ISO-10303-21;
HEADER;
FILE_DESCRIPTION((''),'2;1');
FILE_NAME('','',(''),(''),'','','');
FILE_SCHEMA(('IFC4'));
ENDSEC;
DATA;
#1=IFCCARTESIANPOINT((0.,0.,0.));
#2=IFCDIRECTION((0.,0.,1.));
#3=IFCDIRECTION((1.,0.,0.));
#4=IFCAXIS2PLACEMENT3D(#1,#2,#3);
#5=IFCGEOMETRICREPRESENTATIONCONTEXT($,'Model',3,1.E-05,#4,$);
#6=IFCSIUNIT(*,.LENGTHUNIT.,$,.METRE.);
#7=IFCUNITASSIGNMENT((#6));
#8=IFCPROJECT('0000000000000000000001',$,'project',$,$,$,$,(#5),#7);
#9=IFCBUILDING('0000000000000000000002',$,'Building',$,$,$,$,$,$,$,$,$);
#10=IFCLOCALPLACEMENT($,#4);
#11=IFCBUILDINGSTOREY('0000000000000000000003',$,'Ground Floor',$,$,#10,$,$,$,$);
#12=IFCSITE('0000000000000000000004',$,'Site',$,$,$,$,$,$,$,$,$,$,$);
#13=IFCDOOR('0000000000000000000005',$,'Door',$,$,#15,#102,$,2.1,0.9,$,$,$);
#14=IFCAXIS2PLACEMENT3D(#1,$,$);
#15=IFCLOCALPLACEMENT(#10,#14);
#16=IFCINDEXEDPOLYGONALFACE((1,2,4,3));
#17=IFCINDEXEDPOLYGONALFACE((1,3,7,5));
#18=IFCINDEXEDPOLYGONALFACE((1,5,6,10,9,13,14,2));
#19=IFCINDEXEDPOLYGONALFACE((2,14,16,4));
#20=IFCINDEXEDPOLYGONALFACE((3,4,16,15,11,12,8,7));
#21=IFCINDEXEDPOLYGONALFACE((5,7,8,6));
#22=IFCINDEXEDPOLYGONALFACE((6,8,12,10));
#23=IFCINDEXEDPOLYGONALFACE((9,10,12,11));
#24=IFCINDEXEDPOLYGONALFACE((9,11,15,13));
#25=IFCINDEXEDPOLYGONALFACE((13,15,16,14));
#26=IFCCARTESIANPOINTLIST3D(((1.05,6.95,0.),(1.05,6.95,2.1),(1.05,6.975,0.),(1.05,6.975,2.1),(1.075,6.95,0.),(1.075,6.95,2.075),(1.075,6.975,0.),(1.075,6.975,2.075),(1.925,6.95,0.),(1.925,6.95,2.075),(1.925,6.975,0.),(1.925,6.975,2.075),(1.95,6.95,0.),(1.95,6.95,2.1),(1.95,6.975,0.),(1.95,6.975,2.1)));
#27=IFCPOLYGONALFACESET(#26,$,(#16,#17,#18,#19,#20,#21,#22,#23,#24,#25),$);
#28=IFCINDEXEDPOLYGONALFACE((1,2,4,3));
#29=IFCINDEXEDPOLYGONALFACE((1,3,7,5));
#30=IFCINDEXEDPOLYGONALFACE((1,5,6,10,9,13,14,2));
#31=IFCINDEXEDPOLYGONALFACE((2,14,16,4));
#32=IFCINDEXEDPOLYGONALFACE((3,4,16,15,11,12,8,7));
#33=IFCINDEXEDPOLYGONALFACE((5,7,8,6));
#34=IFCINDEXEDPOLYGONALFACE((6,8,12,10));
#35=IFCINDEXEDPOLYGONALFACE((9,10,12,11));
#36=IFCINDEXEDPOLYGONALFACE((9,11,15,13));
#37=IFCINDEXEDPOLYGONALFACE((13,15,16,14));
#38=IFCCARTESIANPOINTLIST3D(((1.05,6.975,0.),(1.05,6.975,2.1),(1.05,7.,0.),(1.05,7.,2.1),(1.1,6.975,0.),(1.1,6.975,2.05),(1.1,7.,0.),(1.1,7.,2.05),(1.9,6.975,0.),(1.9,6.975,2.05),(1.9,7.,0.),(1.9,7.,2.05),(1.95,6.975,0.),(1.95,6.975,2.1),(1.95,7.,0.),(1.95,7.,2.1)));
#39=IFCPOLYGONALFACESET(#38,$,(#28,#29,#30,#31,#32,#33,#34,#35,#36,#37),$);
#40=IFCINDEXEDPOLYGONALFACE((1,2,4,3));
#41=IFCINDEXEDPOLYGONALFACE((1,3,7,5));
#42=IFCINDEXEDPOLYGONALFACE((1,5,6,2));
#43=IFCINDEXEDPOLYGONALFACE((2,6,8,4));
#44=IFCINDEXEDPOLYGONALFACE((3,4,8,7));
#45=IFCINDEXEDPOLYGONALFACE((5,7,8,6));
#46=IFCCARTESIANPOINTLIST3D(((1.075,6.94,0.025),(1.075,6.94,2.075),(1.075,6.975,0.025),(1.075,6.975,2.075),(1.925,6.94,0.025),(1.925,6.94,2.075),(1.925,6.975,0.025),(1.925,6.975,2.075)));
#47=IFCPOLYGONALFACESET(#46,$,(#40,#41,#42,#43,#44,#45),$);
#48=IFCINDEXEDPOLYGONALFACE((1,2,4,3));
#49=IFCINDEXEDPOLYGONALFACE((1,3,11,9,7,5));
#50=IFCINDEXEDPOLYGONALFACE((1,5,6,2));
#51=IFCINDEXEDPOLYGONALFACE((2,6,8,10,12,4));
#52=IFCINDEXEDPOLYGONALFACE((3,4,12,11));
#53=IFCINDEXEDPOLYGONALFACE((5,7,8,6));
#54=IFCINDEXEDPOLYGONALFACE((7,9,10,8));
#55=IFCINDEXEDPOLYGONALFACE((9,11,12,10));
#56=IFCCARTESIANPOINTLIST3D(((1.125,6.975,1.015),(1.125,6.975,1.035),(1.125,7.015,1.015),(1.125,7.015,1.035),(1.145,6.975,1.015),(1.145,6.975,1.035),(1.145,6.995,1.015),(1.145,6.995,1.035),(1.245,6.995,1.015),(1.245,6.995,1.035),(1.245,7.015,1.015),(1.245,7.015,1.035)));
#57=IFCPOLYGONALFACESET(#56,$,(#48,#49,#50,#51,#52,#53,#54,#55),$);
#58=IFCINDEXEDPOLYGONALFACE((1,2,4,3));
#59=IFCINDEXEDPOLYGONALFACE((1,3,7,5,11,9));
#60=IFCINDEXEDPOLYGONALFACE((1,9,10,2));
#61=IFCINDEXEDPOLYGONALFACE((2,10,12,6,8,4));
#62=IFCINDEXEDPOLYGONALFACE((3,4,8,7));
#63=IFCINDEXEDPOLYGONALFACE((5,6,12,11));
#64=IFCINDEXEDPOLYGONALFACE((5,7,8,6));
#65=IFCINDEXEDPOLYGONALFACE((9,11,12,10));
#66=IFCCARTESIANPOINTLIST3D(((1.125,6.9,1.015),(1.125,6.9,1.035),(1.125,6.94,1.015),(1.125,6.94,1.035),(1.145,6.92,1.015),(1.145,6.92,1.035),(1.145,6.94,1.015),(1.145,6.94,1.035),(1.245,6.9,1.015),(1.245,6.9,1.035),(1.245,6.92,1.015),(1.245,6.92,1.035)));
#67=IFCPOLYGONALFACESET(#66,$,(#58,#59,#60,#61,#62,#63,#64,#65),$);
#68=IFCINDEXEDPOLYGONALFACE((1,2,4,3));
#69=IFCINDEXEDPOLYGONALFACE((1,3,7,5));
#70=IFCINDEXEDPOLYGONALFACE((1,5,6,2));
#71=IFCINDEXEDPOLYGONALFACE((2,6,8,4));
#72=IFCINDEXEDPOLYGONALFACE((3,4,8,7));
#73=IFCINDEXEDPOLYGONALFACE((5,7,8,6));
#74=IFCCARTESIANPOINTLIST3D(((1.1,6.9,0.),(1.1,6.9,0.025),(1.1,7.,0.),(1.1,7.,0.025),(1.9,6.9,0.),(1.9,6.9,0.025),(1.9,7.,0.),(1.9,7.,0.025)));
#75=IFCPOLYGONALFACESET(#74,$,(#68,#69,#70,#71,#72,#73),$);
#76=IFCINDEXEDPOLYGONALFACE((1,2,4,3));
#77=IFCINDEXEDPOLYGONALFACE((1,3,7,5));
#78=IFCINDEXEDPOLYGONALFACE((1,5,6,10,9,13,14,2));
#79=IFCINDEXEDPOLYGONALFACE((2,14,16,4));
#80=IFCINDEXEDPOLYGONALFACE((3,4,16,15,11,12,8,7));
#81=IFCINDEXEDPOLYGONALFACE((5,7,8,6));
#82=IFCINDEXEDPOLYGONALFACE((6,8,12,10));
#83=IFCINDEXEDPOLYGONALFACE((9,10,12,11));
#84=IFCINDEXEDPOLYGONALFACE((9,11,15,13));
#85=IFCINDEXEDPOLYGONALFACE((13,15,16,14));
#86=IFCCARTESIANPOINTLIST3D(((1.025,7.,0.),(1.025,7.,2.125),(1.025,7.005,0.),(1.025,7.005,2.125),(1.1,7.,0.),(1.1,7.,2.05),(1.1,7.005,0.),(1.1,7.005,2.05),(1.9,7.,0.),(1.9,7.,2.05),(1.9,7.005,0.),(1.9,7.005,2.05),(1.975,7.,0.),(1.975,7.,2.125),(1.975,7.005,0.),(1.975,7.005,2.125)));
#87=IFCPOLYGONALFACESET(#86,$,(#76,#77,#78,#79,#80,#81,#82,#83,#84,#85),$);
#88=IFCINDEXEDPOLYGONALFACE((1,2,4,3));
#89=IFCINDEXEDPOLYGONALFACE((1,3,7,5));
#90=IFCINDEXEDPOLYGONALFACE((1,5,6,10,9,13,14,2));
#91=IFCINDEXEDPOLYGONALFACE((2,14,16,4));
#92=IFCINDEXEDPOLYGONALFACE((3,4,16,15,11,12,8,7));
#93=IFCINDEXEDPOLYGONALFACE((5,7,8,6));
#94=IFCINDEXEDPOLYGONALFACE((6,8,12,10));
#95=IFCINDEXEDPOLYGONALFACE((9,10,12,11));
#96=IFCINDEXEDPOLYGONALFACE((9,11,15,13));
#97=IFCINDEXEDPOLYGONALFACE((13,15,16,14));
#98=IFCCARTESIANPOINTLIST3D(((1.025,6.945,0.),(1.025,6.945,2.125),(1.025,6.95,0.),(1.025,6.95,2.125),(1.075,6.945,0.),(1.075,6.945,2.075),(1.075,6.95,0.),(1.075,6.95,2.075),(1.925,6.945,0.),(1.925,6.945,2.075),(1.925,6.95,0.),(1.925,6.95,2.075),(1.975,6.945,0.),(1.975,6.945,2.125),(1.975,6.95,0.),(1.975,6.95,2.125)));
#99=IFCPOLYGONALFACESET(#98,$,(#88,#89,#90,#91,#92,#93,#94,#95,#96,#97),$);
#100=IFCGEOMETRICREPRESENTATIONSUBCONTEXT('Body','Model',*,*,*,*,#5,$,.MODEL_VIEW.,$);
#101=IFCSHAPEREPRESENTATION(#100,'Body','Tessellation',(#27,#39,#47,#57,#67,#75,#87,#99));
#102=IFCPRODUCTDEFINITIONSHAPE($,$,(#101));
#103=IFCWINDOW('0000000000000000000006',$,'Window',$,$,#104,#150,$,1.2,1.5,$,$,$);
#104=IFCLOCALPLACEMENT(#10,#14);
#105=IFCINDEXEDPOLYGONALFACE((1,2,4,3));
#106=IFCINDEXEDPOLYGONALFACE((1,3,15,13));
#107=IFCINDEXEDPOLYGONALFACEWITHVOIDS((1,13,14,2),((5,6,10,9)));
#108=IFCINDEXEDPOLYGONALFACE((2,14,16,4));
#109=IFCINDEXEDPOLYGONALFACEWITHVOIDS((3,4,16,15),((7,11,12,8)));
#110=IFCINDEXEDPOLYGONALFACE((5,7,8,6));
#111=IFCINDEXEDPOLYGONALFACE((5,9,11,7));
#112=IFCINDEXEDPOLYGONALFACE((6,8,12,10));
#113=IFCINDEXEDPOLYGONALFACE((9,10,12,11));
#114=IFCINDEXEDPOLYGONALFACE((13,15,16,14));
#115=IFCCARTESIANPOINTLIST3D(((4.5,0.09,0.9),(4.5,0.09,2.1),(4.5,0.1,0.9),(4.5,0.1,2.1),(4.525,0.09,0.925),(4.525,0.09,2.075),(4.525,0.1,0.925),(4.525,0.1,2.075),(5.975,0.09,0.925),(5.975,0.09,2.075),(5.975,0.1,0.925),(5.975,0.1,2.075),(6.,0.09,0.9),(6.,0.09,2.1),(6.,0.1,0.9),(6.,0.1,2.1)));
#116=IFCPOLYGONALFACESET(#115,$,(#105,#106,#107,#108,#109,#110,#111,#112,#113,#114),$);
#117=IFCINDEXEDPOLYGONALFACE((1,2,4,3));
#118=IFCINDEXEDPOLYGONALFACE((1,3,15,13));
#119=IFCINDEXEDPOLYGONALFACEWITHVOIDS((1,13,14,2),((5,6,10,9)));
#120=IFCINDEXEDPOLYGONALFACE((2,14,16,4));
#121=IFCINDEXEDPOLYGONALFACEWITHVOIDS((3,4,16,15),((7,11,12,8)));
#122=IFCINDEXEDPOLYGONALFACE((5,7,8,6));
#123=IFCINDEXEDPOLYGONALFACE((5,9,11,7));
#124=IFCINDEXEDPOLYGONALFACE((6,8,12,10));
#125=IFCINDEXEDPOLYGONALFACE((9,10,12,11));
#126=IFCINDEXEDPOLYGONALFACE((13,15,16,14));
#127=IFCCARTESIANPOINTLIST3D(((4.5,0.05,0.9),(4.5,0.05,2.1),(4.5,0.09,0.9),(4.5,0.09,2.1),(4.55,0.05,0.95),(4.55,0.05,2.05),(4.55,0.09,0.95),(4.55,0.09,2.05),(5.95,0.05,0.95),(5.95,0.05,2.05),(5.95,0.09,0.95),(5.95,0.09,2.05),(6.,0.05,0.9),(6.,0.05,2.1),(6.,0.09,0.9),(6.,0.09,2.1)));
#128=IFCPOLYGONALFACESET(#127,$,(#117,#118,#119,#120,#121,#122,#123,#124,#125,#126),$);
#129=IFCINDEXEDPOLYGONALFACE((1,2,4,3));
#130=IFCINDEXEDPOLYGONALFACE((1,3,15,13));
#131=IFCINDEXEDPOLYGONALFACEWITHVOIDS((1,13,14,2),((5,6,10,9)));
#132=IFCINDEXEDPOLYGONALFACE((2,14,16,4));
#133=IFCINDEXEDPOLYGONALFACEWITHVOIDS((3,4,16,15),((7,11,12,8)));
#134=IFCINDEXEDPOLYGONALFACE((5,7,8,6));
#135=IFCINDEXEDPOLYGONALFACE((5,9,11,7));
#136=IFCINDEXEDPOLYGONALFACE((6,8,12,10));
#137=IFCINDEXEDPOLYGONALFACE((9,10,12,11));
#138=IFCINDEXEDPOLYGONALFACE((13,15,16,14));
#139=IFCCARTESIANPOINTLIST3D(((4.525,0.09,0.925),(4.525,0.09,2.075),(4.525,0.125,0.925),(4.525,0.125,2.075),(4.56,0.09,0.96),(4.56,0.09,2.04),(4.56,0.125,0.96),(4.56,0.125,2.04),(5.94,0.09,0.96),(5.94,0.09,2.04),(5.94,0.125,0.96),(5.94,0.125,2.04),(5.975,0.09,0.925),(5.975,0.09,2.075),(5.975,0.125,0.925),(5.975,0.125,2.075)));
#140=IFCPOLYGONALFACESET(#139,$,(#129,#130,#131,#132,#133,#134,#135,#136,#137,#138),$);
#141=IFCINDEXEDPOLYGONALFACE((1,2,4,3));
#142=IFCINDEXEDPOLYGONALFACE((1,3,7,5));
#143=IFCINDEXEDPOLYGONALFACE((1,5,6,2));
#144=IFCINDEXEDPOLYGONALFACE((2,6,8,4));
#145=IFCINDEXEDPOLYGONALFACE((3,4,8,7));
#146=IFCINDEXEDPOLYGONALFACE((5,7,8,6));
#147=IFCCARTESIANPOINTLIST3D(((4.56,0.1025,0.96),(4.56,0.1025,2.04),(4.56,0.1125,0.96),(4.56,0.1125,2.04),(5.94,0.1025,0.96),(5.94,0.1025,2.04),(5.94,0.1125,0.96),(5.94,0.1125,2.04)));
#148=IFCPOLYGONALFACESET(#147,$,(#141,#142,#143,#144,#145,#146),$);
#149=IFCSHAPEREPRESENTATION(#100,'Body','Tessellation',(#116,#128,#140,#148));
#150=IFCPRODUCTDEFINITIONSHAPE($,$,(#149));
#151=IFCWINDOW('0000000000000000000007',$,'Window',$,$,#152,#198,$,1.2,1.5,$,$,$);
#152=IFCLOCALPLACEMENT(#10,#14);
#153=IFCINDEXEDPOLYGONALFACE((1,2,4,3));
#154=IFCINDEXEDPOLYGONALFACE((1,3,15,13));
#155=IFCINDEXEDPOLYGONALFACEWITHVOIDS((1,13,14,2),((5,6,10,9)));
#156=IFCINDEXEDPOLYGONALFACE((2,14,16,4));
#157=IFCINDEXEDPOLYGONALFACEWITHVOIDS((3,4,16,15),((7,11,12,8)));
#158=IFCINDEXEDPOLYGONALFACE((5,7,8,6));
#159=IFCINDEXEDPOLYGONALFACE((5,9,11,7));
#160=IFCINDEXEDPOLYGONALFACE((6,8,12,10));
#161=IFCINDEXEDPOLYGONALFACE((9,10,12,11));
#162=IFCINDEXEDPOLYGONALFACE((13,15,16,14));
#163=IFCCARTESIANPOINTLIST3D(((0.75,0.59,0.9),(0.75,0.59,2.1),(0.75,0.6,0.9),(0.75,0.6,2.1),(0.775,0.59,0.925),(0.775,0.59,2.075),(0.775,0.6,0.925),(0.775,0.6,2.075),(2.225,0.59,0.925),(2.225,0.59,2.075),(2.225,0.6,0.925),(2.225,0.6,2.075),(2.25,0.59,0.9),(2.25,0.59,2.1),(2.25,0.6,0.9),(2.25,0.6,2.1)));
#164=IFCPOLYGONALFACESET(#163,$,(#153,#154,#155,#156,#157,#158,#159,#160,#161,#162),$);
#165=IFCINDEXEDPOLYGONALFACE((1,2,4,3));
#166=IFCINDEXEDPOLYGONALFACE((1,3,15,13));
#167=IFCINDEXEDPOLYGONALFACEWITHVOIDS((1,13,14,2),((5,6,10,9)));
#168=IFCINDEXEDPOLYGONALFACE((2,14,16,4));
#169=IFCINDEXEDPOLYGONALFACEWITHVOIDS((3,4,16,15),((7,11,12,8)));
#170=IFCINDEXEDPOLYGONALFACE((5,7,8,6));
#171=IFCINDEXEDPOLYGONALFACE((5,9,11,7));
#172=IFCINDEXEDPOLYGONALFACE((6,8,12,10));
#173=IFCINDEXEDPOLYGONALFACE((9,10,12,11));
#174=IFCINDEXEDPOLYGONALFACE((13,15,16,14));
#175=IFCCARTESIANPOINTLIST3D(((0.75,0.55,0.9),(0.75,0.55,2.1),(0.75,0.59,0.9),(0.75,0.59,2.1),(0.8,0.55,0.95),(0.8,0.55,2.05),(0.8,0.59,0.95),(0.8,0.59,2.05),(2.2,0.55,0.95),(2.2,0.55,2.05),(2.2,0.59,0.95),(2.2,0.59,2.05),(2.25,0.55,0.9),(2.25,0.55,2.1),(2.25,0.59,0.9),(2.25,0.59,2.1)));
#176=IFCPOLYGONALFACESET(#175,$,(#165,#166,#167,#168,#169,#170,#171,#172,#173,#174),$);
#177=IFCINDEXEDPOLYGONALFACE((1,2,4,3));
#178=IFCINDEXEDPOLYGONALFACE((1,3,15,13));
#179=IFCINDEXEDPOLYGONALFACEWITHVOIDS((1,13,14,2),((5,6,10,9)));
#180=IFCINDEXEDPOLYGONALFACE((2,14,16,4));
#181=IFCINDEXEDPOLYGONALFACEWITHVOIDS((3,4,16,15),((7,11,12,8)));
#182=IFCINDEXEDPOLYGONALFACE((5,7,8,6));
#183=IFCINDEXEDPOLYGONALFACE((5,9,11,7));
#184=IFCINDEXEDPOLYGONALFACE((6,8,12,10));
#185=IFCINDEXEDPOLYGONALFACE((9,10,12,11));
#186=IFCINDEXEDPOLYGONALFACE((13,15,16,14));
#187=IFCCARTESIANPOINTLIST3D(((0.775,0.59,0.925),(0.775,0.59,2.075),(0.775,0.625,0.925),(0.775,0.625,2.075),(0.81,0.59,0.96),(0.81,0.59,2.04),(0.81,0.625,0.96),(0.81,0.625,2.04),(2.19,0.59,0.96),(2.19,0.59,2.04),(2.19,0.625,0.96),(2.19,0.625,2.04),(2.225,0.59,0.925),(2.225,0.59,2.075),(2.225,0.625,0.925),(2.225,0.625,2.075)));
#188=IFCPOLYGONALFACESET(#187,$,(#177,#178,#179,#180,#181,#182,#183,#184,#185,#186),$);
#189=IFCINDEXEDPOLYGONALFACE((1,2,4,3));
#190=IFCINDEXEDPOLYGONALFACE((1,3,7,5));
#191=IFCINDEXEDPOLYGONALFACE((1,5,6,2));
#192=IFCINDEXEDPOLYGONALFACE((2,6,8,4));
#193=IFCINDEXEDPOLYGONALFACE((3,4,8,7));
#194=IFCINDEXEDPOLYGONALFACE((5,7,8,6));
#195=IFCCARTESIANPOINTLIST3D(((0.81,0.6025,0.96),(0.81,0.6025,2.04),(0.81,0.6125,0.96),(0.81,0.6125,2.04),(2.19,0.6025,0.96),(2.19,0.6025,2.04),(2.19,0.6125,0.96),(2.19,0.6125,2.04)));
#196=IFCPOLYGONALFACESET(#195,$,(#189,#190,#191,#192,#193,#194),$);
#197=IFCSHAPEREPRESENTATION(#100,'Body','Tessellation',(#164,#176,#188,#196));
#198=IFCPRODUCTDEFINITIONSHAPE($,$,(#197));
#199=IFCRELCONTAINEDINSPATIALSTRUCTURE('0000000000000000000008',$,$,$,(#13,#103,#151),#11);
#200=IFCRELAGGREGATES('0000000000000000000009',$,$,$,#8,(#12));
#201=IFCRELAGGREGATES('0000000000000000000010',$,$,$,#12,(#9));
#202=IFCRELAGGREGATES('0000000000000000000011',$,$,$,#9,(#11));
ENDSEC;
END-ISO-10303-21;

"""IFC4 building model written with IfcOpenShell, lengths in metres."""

from ifc_helpers import new_model, si_unit, frame, origin_with_axes, place, context, subcontext, project, spatial, line, indexed_curve, outline, extrude, element, save


model = new_model("IFC4")

# Units and contexts
model_context = context("Model", 3, precision=1e-05, world=origin_with_axes())
body_context = subcontext(model_context, "Body", "Model", "MODEL_VIEW")
ifc_project = project(units=[si_unit("LENGTHUNIT", "METRE")], contexts=[model_context])

# Site, building, storey
site = spatial("IfcSite", under=ifc_project, Name="Site")
building = spatial("IfcBuilding", under=site, Name="Building")
storey_placement = place(None, origin_with_axes())
storey = spatial("IfcBuildingStorey", under=building, at=storey_placement, Name="Ground Floor")

# Door
door_1_placement = place(storey_placement, frame((1.95, 7.0, 0.0), z_axis=(0.0, 0.0, 1.0), x_axis=(-1.0, 0.0, 0.0)))
element("IfcDoor", 1, at=door_1_placement, inside=storey, Name="Door", OverallHeight=2.1, OverallWidth=0.9, context=body_context, shape_type="SweptSolid", body=[
    extrude(outline(indexed_curve([(0.0, 0.0), (0.0, 2.1), (0.9, 2.1), (0.9, 0.0), (0.875, 0.0), (0.875, 2.075), (0.025, 2.075), (0.025, 0.0)], segments=[line(1, 2, 3, 4, 5, 6, 7, 8, 1)])), frame((0.0, 0.025, 0.0), z_axis=(0.0, -1.0, 0.0), x_axis=(1.0, 0.0, 0.0)), (0.0, 0.0, -1.0), 0.025),
    extrude(outline(indexed_curve([(0.0, 0.0), (0.0, 2.1), (0.9, 2.1), (0.9, 0.0), (0.85, 0.0), (0.85, 2.05), (0.05, 2.05), (0.05, 0.0)], segments=[line(1, 2, 3, 4, 5, 6, 7, 8, 1)])), frame((0.0, 0.0, 0.0), z_axis=(0.0, -1.0, 0.0), x_axis=(1.0, 0.0, 0.0)), (0.0, 0.0, -1.0), 0.025),
    extrude(outline(indexed_curve([(0.0, 0.0), (0.85, 0.0), (0.85, 0.035), (0.0, 0.035)], segments=[line(1, 2, 3, 4, 1)])), frame((0.025, 0.025, 0.025), z_axis=(0.0, 0.0, 1.0), x_axis=(1.0, 0.0, 0.0)), (0.0, 0.0, 1.0), 2.05),
    extrude(outline(indexed_curve([(0.0, 0.0), (0.0, -0.04), (-0.12, -0.04), (-0.12, -0.02), (-0.02, -0.02), (-0.02, 0.0)], segments=[line(1, 2, 3, 4, 5, 6, 1)])), frame((0.825, 0.025, 1.015), z_axis=(0.0, 0.0, 1.0), x_axis=(1.0, 0.0, 0.0)), (0.0, 0.0, 1.0), 0.02),
    extrude(outline(indexed_curve([(0.0, 0.0), (0.0, 0.04), (-0.12, 0.04), (-0.12, 0.02), (-0.02, 0.02), (-0.02, 0.0)], segments=[line(1, 2, 3, 4, 5, 6, 1)])), frame((0.825, 0.06, 1.015), z_axis=(0.0, 0.0, 1.0), x_axis=(1.0, 0.0, 0.0)), (0.0, 0.0, 1.0), 0.02),
    extrude(outline(indexed_curve([(0.0, 0.0), (0.8, 0.0), (0.8, 0.1), (0.0, 0.1)], segments=[line(1, 2, 3, 4, 1)])), frame((0.05, 0.0, 0.0), z_axis=(0.0, 0.0, 1.0), x_axis=(1.0, 0.0, 0.0)), (0.0, 0.0, 1.0), 0.025),
    extrude(outline(indexed_curve([(0.0, 0.0), (0.0, 2.125), (0.95, 2.125), (0.95, 0.0), (0.875, 0.0), (0.875, 2.05), (0.075, 2.05), (0.075, 0.0)], segments=[line(1, 2, 3, 4, 5, 6, 7, 8, 1)])), frame((-0.025, -0.005, 0.0), z_axis=(0.0, -1.0, 0.0), x_axis=(1.0, 0.0, 0.0)), (0.0, 0.0, -1.0), 0.005),
    extrude(outline(indexed_curve([(0.0, 0.0), (0.0, 2.125), (0.95, 2.125), (0.95, 0.0), (0.9, 0.0), (0.9, 2.075), (0.05, 2.075), (0.05, 0.0)], segments=[line(1, 2, 3, 4, 5, 6, 7, 8, 1)])), frame((-0.025, 0.05, 0.0), z_axis=(0.0, -1.0, 0.0), x_axis=(1.0, 0.0, 0.0)), (0.0, 0.0, -1.0), 0.005),
])

# Windows
for number, where, z_axis, x_axis, name in (
    (2, (4.5, 0.0, 0.9), (0.0, 0.0, 1.0), (1.0, 0.0, 0.0), "Window"),
    (3, (0.75, 0.5, 0.9), (0.0, 0.0, 1.0), (1.0, 0.0, 0.0), "Window"),
):
    element("IfcWindow", number, at=place(storey_placement, frame(where, z_axis=z_axis, x_axis=x_axis)), inside=storey, Name=name, OverallHeight=1.2, OverallWidth=1.5, context=body_context, shape_type="SweptSolid", body=[
        extrude(outline(indexed_curve([(0.0, 0.0), (1.5, 0.0), (1.5, 1.2), (0.0, 1.2)], segments=[line(1, 2, 3, 4, 1)]), holes=[indexed_curve([(0.025, 0.025), (1.475, 0.025), (1.475, 1.175), (0.025, 1.175)], segments=[line(1, 2, 3, 4, 1)])]), frame((0.0, 0.09, 0.0), z_axis=(0.0, -1.0, 0.0), x_axis=(1.0, 0.0, 0.0)), (0.0, 0.0, -1.0), 0.01),
        extrude(outline(indexed_curve([(0.0, 0.0), (1.5, 0.0), (1.5, 1.2), (0.0, 1.2)], segments=[line(1, 2, 3, 4, 1)]), holes=[indexed_curve([(0.05, 0.05), (1.45, 0.05), (1.45, 1.15), (0.05, 1.15)], segments=[line(1, 2, 3, 4, 1)])]), frame((0.0, 0.05, 0.0), z_axis=(0.0, -1.0, 0.0), x_axis=(1.0, 0.0, 0.0)), (0.0, 0.0, -1.0), 0.04),
        extrude(outline(indexed_curve([(0.0, 0.0), (1.45, 0.0), (1.45, 1.15), (0.0, 1.15)], segments=[line(1, 2, 3, 4, 1)]), holes=[indexed_curve([(0.035, 0.035), (1.415, 0.035), (1.415, 1.115), (0.035, 1.115)], segments=[line(1, 2, 3, 4, 1)])]), frame((0.025, 0.09, 0.025), z_axis=(0.0, -1.0, 0.0), x_axis=(1.0, 0.0, 0.0)), (0.0, 0.0, -1.0), 0.035),
        extrude(outline(indexed_curve([(0.035, 0.035), (1.415, 0.035), (1.415, 1.115), (0.035, 1.115)], segments=[line(1, 2, 3, 4, 1)])), frame((0.025, 0.1025, 0.025), z_axis=(0.0, -1.0, 0.0), x_axis=(1.0, 0.0, 0.0)), (0.0, 0.0, -1.0), 0.01),
    ])

save(model, "model.ifc")
